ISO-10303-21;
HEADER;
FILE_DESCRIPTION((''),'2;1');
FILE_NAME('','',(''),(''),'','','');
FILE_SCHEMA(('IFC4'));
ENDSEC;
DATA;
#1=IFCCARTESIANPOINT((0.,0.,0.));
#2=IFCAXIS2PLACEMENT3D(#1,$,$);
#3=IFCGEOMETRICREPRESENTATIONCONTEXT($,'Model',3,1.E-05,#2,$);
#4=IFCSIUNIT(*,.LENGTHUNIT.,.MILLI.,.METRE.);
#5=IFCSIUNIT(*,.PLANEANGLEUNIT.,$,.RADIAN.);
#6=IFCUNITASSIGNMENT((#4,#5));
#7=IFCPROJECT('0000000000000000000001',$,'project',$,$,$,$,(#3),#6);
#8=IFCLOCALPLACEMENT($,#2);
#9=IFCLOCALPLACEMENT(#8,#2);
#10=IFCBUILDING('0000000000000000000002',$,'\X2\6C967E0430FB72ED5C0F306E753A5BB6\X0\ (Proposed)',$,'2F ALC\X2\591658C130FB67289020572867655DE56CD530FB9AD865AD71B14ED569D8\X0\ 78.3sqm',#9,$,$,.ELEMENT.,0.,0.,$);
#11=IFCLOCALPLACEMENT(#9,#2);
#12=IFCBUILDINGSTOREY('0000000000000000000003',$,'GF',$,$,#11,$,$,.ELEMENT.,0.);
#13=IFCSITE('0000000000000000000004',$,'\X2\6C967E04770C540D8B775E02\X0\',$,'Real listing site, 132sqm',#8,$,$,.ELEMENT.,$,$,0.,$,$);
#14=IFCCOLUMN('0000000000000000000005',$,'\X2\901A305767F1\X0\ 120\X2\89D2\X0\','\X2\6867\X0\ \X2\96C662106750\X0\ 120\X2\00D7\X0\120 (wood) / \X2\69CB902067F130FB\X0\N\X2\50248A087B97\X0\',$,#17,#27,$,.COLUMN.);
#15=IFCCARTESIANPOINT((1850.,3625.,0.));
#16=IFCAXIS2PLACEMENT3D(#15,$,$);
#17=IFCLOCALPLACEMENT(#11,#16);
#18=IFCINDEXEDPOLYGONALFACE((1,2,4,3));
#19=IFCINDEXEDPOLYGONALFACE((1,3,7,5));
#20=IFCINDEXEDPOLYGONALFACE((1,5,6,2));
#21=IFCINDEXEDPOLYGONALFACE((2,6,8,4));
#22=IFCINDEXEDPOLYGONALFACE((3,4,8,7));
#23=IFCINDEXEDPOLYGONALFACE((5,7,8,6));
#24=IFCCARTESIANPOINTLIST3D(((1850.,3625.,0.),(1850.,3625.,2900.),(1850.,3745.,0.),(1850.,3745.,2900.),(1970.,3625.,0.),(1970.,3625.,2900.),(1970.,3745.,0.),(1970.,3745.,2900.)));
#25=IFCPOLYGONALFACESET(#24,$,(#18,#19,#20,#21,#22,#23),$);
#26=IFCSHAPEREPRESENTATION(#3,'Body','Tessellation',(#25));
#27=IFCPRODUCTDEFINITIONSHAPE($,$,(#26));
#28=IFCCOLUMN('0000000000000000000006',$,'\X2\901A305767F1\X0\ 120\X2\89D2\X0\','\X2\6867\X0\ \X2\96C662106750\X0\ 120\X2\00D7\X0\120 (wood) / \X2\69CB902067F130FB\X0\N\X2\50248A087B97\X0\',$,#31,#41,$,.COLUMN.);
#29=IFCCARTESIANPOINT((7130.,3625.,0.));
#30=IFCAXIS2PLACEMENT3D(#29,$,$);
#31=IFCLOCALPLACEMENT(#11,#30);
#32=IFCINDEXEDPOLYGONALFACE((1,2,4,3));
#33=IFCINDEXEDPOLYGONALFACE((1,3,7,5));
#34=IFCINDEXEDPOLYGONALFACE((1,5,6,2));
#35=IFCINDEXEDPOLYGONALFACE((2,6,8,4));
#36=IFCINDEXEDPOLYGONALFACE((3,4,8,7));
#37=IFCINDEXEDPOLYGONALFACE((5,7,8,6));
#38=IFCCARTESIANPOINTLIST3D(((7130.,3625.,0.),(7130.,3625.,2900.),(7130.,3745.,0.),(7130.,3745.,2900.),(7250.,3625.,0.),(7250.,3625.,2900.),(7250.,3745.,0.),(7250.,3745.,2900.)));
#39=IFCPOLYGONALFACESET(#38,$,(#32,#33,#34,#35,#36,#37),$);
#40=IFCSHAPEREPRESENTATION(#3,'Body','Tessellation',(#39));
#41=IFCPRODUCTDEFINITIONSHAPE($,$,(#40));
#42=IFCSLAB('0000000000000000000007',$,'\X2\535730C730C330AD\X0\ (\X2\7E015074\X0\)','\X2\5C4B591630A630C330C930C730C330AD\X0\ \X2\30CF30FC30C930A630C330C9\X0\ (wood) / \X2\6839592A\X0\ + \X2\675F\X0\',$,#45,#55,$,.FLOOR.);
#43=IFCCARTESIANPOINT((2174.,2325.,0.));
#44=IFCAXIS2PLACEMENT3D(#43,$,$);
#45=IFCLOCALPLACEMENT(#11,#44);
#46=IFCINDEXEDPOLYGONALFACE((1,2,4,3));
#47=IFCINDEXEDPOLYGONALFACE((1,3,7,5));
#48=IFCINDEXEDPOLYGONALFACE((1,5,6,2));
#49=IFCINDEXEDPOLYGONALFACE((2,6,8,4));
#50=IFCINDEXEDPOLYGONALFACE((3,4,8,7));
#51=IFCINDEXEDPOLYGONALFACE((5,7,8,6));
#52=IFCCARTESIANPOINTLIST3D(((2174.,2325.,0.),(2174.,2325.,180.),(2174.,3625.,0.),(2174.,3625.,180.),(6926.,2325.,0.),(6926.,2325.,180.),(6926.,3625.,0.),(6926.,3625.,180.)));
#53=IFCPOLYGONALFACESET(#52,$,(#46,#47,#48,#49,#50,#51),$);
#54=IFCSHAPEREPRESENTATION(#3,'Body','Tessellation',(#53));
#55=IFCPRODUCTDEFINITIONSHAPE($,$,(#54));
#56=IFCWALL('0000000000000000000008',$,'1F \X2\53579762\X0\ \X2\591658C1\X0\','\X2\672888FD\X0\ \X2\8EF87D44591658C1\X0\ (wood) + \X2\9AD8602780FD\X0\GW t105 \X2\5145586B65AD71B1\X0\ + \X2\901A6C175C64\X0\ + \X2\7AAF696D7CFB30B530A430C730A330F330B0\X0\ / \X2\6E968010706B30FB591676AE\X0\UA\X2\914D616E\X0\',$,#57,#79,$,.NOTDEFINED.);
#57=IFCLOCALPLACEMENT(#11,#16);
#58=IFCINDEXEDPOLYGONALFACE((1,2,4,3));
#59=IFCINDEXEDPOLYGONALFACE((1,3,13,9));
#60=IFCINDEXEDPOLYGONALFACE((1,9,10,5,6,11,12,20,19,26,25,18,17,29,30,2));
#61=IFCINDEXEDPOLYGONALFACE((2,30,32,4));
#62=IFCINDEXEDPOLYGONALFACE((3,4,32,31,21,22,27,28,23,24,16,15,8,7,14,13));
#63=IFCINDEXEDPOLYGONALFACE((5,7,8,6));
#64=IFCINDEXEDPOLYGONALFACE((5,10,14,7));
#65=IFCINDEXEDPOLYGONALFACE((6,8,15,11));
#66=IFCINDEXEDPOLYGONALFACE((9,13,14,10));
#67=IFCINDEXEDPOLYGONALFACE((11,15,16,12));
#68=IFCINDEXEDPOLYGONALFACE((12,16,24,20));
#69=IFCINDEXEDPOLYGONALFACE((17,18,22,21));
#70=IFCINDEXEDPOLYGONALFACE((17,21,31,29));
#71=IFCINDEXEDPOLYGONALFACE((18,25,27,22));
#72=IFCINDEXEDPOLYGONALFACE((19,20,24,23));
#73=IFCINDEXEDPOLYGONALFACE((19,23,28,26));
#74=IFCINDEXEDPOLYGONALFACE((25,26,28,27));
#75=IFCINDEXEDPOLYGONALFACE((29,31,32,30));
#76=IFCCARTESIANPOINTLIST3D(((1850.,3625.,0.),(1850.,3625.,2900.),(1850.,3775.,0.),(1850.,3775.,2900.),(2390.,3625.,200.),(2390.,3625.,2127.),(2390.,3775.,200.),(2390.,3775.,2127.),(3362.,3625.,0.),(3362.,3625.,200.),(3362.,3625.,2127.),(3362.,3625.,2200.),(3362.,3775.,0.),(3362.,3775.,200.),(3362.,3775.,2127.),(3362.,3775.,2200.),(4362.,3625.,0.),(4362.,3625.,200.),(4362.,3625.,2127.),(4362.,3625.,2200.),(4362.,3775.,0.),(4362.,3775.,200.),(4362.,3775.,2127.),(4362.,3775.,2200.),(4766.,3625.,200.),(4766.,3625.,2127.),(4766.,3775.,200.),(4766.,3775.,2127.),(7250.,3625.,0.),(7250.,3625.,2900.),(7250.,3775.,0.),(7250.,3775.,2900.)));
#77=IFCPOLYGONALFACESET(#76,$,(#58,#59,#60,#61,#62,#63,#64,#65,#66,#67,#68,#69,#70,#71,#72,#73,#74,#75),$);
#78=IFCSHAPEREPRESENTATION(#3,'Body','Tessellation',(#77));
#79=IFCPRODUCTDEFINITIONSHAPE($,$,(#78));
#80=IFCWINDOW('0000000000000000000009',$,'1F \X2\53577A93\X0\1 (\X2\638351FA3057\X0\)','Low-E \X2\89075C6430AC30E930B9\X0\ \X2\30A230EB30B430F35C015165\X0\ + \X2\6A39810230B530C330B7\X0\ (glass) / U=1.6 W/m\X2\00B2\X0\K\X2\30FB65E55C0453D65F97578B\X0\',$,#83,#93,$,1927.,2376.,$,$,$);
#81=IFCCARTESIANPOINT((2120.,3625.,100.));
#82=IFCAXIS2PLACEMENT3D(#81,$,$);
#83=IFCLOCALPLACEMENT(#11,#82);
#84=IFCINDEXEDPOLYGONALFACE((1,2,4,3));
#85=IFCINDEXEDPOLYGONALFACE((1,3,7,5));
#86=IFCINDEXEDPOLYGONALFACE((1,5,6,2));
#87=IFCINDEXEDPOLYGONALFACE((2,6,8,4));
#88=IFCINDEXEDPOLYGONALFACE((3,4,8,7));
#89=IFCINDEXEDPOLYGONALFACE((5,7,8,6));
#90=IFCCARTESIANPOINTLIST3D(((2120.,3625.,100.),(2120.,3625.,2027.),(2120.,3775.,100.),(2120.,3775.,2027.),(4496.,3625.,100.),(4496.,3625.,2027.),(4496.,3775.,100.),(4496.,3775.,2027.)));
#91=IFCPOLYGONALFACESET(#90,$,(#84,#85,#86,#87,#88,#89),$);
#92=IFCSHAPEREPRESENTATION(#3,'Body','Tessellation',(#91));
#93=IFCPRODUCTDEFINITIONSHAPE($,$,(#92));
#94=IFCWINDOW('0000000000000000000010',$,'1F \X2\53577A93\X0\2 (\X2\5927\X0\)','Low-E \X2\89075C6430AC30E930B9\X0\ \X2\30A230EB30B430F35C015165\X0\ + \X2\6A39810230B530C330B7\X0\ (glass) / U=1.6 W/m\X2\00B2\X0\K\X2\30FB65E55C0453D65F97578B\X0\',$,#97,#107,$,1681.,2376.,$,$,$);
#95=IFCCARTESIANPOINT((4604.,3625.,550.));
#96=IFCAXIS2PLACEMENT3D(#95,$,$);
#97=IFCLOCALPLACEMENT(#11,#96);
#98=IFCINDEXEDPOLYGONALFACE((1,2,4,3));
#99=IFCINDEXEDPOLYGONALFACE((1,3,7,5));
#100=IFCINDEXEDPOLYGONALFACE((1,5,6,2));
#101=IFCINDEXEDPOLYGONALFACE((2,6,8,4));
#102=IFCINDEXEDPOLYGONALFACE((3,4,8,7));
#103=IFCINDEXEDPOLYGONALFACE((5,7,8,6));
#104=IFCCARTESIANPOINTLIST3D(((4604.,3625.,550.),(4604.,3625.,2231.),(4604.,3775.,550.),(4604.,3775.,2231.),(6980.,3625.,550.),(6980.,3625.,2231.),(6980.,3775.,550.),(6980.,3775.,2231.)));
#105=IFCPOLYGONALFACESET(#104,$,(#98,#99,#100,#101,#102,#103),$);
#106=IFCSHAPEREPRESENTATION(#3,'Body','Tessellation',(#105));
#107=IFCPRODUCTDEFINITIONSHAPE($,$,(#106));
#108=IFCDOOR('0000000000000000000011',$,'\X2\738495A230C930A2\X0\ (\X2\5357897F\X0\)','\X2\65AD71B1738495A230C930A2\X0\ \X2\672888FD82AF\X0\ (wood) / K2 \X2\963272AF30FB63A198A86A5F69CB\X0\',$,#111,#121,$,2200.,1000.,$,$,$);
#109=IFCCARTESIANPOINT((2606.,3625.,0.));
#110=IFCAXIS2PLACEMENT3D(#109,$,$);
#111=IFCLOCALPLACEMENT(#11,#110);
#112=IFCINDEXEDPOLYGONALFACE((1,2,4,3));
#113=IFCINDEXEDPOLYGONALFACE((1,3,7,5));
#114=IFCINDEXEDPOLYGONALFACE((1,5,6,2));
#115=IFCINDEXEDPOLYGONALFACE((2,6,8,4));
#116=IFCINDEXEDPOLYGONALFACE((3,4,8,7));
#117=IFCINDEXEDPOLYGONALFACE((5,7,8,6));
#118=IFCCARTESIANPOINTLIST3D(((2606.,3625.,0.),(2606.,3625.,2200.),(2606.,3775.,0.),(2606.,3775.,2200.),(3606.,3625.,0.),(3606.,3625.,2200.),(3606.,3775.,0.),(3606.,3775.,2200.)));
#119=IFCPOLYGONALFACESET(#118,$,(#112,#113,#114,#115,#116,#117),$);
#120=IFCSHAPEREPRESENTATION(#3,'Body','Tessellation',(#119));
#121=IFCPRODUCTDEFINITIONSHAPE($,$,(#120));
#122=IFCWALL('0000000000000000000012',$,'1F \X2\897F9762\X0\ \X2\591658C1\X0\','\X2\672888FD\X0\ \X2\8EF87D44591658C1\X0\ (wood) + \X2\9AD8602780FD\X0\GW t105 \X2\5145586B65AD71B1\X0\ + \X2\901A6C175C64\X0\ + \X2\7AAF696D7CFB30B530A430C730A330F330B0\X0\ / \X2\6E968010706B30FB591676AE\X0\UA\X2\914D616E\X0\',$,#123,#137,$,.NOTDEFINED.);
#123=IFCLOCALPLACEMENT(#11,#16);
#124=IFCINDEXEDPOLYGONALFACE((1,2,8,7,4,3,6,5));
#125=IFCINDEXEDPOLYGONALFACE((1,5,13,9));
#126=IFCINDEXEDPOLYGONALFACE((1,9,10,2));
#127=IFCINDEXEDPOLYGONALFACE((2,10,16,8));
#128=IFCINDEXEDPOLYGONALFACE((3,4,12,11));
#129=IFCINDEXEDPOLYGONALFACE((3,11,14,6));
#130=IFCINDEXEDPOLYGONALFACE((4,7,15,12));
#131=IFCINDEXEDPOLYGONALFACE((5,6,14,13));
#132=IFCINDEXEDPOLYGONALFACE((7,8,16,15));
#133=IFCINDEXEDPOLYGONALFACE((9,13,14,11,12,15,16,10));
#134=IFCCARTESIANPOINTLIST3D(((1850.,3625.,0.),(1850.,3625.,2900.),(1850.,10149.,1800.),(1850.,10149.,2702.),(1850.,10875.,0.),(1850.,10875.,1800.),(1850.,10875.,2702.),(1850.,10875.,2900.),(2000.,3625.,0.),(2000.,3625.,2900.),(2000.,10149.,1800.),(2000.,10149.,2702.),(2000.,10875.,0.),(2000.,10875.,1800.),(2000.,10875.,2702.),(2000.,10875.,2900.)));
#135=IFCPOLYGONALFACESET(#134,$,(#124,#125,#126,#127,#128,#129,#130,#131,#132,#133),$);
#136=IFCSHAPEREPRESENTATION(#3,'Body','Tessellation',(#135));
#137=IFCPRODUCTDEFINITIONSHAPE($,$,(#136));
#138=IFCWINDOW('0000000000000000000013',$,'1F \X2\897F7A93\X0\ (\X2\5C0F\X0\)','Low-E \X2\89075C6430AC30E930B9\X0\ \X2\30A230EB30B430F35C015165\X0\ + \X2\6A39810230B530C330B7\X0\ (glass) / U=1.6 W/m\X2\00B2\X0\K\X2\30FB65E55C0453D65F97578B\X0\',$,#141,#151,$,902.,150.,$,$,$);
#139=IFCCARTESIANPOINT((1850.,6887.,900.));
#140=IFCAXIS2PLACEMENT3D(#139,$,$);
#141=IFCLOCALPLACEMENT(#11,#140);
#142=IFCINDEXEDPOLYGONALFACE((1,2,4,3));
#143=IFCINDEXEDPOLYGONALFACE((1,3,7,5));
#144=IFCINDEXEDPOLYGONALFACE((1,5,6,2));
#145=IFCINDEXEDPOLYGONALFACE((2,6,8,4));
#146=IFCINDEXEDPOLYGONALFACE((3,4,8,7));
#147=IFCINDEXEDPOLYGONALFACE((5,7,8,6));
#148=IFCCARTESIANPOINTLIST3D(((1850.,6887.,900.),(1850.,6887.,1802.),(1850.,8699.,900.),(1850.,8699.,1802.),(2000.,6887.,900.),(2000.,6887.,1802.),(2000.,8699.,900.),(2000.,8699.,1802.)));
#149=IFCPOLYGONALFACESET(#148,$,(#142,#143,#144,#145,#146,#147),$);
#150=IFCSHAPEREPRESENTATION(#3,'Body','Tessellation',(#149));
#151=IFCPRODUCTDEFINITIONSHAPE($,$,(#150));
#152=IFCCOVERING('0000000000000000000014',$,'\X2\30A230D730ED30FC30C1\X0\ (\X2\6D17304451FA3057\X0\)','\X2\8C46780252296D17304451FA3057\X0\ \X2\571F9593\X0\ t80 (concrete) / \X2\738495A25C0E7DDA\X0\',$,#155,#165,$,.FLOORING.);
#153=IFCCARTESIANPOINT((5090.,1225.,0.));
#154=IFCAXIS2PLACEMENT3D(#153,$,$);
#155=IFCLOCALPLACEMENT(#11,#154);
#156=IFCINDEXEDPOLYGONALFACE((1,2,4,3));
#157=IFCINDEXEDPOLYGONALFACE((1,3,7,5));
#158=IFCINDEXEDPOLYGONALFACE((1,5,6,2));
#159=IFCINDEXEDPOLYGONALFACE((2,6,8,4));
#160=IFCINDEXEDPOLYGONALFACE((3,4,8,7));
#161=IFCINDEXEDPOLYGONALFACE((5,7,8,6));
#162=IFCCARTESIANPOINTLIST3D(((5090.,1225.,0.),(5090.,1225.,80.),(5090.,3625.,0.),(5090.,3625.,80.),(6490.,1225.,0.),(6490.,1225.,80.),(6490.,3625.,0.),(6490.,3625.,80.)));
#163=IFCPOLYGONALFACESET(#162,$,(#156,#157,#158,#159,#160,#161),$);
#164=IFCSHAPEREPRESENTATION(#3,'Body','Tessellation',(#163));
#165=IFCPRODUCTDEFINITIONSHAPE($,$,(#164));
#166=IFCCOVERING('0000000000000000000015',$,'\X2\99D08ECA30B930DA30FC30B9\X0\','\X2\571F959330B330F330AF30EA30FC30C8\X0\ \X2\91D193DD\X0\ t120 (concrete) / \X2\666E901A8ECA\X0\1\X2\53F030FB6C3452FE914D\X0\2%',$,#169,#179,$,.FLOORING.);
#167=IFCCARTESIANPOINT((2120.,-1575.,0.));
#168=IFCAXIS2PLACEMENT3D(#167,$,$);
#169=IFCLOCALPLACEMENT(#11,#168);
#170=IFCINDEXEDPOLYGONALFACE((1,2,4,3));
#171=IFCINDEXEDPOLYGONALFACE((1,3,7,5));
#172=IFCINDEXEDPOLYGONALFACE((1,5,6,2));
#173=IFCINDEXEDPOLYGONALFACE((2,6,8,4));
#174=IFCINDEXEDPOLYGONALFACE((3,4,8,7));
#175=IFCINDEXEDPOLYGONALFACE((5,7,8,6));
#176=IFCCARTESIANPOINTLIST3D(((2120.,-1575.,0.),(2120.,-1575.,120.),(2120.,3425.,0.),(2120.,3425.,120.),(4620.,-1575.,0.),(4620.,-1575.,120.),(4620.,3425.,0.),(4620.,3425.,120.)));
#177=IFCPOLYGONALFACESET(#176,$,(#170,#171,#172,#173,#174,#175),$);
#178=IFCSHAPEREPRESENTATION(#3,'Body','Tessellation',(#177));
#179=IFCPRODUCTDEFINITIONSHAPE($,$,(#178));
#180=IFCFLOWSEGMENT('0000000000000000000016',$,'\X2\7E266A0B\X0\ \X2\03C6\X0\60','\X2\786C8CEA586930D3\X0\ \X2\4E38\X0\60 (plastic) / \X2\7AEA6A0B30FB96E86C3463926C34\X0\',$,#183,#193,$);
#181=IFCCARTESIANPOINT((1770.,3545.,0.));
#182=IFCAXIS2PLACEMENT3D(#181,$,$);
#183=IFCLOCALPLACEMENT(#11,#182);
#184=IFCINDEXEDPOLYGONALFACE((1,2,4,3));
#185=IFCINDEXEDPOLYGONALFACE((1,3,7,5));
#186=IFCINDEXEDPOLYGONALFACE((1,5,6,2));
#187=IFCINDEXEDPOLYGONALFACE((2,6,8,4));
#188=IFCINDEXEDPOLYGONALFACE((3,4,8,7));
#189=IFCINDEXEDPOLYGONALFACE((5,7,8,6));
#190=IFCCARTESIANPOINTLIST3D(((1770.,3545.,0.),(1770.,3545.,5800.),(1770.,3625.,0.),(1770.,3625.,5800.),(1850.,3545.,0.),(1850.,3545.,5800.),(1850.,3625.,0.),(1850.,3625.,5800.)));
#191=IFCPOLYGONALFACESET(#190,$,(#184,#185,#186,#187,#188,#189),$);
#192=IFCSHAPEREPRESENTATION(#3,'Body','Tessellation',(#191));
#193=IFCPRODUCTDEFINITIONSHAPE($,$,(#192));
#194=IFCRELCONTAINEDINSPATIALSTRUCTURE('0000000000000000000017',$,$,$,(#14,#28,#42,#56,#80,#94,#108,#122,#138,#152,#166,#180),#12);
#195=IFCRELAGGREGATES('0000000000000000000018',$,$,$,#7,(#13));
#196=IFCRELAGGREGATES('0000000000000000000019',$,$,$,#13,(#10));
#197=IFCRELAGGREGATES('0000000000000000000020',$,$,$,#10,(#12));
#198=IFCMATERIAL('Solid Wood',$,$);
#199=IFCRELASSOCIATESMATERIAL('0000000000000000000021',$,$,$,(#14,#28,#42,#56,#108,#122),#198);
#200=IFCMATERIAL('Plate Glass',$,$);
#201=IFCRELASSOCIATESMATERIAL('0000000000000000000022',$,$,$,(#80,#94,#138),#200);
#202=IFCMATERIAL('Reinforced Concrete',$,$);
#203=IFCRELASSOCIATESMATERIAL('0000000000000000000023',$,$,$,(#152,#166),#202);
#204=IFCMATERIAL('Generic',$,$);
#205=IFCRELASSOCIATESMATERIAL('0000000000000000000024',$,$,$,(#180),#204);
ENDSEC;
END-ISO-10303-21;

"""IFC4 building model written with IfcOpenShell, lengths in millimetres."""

from ifc_helpers import new_model, si_unit, frame, frame_2d, origin, place, context, project, spatial, rectangle, extrude, material, element, fill, save


model = new_model("IFC4")

# Units and contexts
model_context = context("Model", 3, precision=1e-05, world=origin())
ifc_project = project(units=[si_unit("LENGTHUNIT", "METRE", prefix="MILLI"), si_unit("PLANEANGLEUNIT", "RADIAN")], contexts=[model_context])

# Site, building, storey
site_placement = place(None, origin())
site = spatial("IfcSite", under=ifc_project, at=site_placement, Name="沖縄県名護市", ObjectType="Real listing site, 132sqm", CompositionType="ELEMENT", RefElevation=0.0)
building_placement = place(site_placement, origin())
building = spatial("IfcBuilding", under=site, at=building_placement, Name="沖縄・狭小の町家 (Proposed)", ObjectType="2F ALC外壁・木造在来工法・高断熱仕様 78.3sqm", CompositionType="ELEMENT", ElevationOfRefHeight=0.0, ElevationOfTerrain=0.0)
storey_placement = place(building_placement, origin())
storey = spatial("IfcBuildingStorey", under=building, at=storey_placement, Name="GF", CompositionType="ELEMENT", Elevation=0.0)

# Columns
ifc_material_1 = material(Name="Solid Wood")
column_1_placement = place(storey_placement, frame((1850.0, 3625.0, 0.0)))
element("IfcColumn", 1, at=column_1_placement, inside=storey, material=ifc_material_1, Name="通し柱 120角", Description="桧 集成材 120×120 (wood) / 構造柱・N値計算", PredefinedType="COLUMN", context=model_context, shape_type="SweptSolid", body=[
    extrude(rectangle(XDim=120.0, YDim=120.0, at=frame_2d((60.0, 60.0))), frame((1850.0, 3625.0, 0.0)), (0.0, 0.0, 1.0), 2900.0),
])
column_2_placement = place(storey_placement, frame((7130.0, 3625.0, 0.0)))
element("IfcColumn", 2, at=column_2_placement, inside=storey, material=ifc_material_1, Name="通し柱 120角", Description="桧 集成材 120×120 (wood) / 構造柱・N値計算", PredefinedType="COLUMN", context=model_context, shape_type="SweptSolid", body=[
    extrude(rectangle(XDim=120.0, YDim=120.0, at=frame_2d((60.0, 60.0))), frame((7130.0, 3625.0, 0.0)), (0.0, 0.0, 1.0), 2900.0),
])

# Slab
ifc_material_2 = material(Name="Reinforced Concrete")
slab_1_placement = place(storey_placement, frame((2174.0, 2325.0, 0.0)))
element("IfcSlab", 3, at=slab_1_placement, inside=storey, material=ifc_material_1, Name="南デッキ (縁側)", Description="屋外ウッドデッキ ハードウッド (wood) / 根太 + 束", PredefinedType="FLOOR", context=model_context, shape_type="SweptSolid", body=[
    extrude(rectangle(XDim=4752.0, YDim=1300.0, at=frame_2d((2376.0, 650.0))), frame((2174.0, 2325.0, 0.0)), (0.0, 0.0, 1.0), 180.0),
])

# Wall, openings, windows, door
wall_1_placement = place(storey_placement, frame((1850.0, 3625.0, 0.0)))
wall_1 = element("IfcWall", 4, at=wall_1_placement, inside=storey, material=ifc_material_1, Name="1F 南面 外壁", Description="木製 軸組外壁 (wood) + 高性能GW t105 充填断熱 + 通気層 + 窯業系サイディング / 準耐火・外皮UA配慮", PredefinedType="NOTDEFINED", context=model_context, shape_type="SweptSolid", body=[
    extrude(rectangle(XDim=5400.0, YDim=150.0, at=frame_2d((2700.0, 75.0))), frame((1850.0, 3625.0, 0.0)), (0.0, 0.0, 1.0), 2900.0),
])
opening_1_placement = place(storey_placement, frame((2120.0, 3625.0, 100.0)))
opening_1 = element("IfcOpeningElement", 5, at=opening_1_placement, cuts=wall_1, PredefinedType="NOTDEFINED", context=model_context, shape_type="SweptSolid", body=[
    extrude(rectangle(XDim=2376.0, YDim=150.0, at=frame_2d((1188.0, 75.0))), frame((2120.0, 3625.0, 100.0)), (0.0, 0.0, 1.0), 1927.0),
])
opening_2_placement = place(storey_placement, frame((4604.0, 3625.0, 550.0)))
opening_2 = element("IfcOpeningElement", 6, at=opening_2_placement, cuts=wall_1, PredefinedType="NOTDEFINED", context=model_context, shape_type="SweptSolid", body=[
    extrude(rectangle(XDim=2376.0, YDim=150.0, at=frame_2d((1188.0, 75.0))), frame((4604.0, 3625.0, 550.0)), (0.0, 0.0, 1.0), 1681.0),
])
opening_3_placement = place(storey_placement, frame((2606.0, 3625.0, 0.0)))
opening_3 = element("IfcOpeningElement", 7, at=opening_3_placement, cuts=wall_1, PredefinedType="NOTDEFINED", context=model_context, shape_type="SweptSolid", body=[
    extrude(rectangle(XDim=1000.0, YDim=150.0, at=frame_2d((500.0, 75.0))), frame((2606.0, 3625.0, 0.0)), (0.0, 0.0, 1.0), 2200.0),
])
ifc_material_3 = material(Name="Plate Glass")
window_1_placement = place(storey_placement, frame((2120.0, 3625.0, 100.0)))
window_1 = element("IfcWindow", 8, at=window_1_placement, inside=storey, material=ifc_material_3, Name="1F 南窓1 (掃出し)", Description="Low-E 複層ガラス アルゴン封入 + 樹脂サッシ (glass) / U=1.6 W/m²K・日射取得型", OverallHeight=1927.0, OverallWidth=2376.0, context=model_context, shape_type="SweptSolid", body=[
    extrude(rectangle(XDim=2376.0, YDim=150.0, at=frame_2d((1188.0, 75.0))), frame((2120.0, 3625.0, 100.0)), (0.0, 0.0, 1.0), 1927.0),
])
fill(opening_1, window_1)
window_2_placement = place(storey_placement, frame((4604.0, 3625.0, 550.0)))
window_2 = element("IfcWindow", 9, at=window_2_placement, inside=storey, material=ifc_material_3, Name="1F 南窓2 (大)", Description="Low-E 複層ガラス アルゴン封入 + 樹脂サッシ (glass) / U=1.6 W/m²K・日射取得型", OverallHeight=1681.0, OverallWidth=2376.0, context=model_context, shape_type="SweptSolid", body=[
    extrude(rectangle(XDim=2376.0, YDim=150.0, at=frame_2d((1188.0, 75.0))), frame((4604.0, 3625.0, 550.0)), (0.0, 0.0, 1.0), 1681.0),
])
fill(opening_2, window_2)
door_placement = place(storey_placement, frame((2606.0, 3625.0, 0.0)))
door = element("IfcDoor", 10, at=door_placement, inside=storey, material=ifc_material_1, Name="玄関ドア (南西)", Description="断熱玄関ドア 木製芯 (wood) / K2 防犯・採風機構", OverallHeight=2200.0, OverallWidth=1000.0, context=model_context, shape_type="SweptSolid", body=[
    extrude(rectangle(XDim=1000.0, YDim=150.0, at=frame_2d((500.0, 75.0))), frame((2606.0, 3625.0, 0.0)), (0.0, 0.0, 1.0), 2200.0),
])
fill(opening_3, door)

# Wall, opening, window
wall_2_placement = place(storey_placement, frame((1850.0, 3625.0, 0.0)))
wall_2 = element("IfcWall", 11, at=wall_2_placement, inside=storey, material=ifc_material_1, Name="1F 西面 外壁", Description="木製 軸組外壁 (wood) + 高性能GW t105 充填断熱 + 通気層 + 窯業系サイディング / 準耐火・外皮UA配慮", PredefinedType="NOTDEFINED", context=model_context, shape_type="SweptSolid", body=[
    extrude(rectangle(XDim=150.0, YDim=7250.0, at=frame_2d((75.0, 3625.0))), frame((1850.0, 3625.0, 0.0)), (0.0, 0.0, 1.0), 2900.0),
])
opening_4_placement = place(storey_placement, frame((1850.0, 6887.0, 900.0)))
opening_4 = element("IfcOpeningElement", 12, at=opening_4_placement, cuts=wall_2, PredefinedType="NOTDEFINED", context=model_context, shape_type="SweptSolid", body=[
    extrude(rectangle(XDim=150.0, YDim=1812.0, at=frame_2d((75.0, 906.0))), frame((1850.0, 6887.0, 900.0)), (0.0, 0.0, 1.0), 902.0),
])
window_3_placement = place(storey_placement, frame((1850.0, 6887.0, 900.0)))
window_3 = element("IfcWindow", 13, at=window_3_placement, inside=storey, material=ifc_material_3, Name="1F 西窓 (小)", Description="Low-E 複層ガラス アルゴン封入 + 樹脂サッシ (glass) / U=1.6 W/m²K・日射取得型", OverallHeight=902.0, OverallWidth=150.0, context=model_context, shape_type="SweptSolid", body=[
    extrude(rectangle(XDim=150.0, YDim=1812.0, at=frame_2d((75.0, 906.0))), frame((1850.0, 6887.0, 900.0)), (0.0, 0.0, 1.0), 902.0),
])
fill(opening_4, window_3)

# Coverings
covering_1_placement = place(storey_placement, frame((5090.0, 1225.0, 0.0)))
element("IfcCovering", 14, at=covering_1_placement, inside=storey, material=ifc_material_2, Name="アプローチ (洗い出し)", Description="豆砂利洗い出し 土間 t80 (concrete) / 玄関導線", PredefinedType="FLOORING", context=model_context, shape_type="SweptSolid", body=[
    extrude(rectangle(XDim=1400.0, YDim=2400.0, at=frame_2d((700.0, 1200.0))), frame((5090.0, 1225.0, 0.0)), (0.0, 0.0, 1.0), 80.0),
])
covering_2_placement = place(storey_placement, frame((2120.0, -1575.0, 0.0)))
element("IfcCovering", 15, at=covering_2_placement, inside=storey, material=ifc_material_2, Name="駐車スペース", Description="土間コンクリート 金鏝 t120 (concrete) / 普通車1台・水勾配2%", PredefinedType="FLOORING", context=model_context, shape_type="SweptSolid", body=[
    extrude(rectangle(XDim=2500.0, YDim=5000.0, at=frame_2d((1250.0, 2500.0))), frame((2120.0, -1575.0, 0.0)), (0.0, 0.0, 1.0), 120.0),
])

# Flow segment
ifc_material_4 = material(Name="Generic")
flow_segment_1_placement = place(storey_placement, frame((1770.0, 3545.0, 0.0)))
element("IfcFlowSegment", 16, at=flow_segment_1_placement, inside=storey, material=ifc_material_4, Name="縦樋 φ60", Description="硬質塩ビ 丸60 (plastic) / 竪樋・雨水排水", context=model_context, shape_type="SweptSolid", body=[
    extrude(rectangle(XDim=80.0, YDim=80.0, at=frame_2d((40.0, 40.0))), frame((1770.0, 3545.0, 0.0)), (0.0, 0.0, 1.0), 5800.0),
])

save(model, "model.ifc")
